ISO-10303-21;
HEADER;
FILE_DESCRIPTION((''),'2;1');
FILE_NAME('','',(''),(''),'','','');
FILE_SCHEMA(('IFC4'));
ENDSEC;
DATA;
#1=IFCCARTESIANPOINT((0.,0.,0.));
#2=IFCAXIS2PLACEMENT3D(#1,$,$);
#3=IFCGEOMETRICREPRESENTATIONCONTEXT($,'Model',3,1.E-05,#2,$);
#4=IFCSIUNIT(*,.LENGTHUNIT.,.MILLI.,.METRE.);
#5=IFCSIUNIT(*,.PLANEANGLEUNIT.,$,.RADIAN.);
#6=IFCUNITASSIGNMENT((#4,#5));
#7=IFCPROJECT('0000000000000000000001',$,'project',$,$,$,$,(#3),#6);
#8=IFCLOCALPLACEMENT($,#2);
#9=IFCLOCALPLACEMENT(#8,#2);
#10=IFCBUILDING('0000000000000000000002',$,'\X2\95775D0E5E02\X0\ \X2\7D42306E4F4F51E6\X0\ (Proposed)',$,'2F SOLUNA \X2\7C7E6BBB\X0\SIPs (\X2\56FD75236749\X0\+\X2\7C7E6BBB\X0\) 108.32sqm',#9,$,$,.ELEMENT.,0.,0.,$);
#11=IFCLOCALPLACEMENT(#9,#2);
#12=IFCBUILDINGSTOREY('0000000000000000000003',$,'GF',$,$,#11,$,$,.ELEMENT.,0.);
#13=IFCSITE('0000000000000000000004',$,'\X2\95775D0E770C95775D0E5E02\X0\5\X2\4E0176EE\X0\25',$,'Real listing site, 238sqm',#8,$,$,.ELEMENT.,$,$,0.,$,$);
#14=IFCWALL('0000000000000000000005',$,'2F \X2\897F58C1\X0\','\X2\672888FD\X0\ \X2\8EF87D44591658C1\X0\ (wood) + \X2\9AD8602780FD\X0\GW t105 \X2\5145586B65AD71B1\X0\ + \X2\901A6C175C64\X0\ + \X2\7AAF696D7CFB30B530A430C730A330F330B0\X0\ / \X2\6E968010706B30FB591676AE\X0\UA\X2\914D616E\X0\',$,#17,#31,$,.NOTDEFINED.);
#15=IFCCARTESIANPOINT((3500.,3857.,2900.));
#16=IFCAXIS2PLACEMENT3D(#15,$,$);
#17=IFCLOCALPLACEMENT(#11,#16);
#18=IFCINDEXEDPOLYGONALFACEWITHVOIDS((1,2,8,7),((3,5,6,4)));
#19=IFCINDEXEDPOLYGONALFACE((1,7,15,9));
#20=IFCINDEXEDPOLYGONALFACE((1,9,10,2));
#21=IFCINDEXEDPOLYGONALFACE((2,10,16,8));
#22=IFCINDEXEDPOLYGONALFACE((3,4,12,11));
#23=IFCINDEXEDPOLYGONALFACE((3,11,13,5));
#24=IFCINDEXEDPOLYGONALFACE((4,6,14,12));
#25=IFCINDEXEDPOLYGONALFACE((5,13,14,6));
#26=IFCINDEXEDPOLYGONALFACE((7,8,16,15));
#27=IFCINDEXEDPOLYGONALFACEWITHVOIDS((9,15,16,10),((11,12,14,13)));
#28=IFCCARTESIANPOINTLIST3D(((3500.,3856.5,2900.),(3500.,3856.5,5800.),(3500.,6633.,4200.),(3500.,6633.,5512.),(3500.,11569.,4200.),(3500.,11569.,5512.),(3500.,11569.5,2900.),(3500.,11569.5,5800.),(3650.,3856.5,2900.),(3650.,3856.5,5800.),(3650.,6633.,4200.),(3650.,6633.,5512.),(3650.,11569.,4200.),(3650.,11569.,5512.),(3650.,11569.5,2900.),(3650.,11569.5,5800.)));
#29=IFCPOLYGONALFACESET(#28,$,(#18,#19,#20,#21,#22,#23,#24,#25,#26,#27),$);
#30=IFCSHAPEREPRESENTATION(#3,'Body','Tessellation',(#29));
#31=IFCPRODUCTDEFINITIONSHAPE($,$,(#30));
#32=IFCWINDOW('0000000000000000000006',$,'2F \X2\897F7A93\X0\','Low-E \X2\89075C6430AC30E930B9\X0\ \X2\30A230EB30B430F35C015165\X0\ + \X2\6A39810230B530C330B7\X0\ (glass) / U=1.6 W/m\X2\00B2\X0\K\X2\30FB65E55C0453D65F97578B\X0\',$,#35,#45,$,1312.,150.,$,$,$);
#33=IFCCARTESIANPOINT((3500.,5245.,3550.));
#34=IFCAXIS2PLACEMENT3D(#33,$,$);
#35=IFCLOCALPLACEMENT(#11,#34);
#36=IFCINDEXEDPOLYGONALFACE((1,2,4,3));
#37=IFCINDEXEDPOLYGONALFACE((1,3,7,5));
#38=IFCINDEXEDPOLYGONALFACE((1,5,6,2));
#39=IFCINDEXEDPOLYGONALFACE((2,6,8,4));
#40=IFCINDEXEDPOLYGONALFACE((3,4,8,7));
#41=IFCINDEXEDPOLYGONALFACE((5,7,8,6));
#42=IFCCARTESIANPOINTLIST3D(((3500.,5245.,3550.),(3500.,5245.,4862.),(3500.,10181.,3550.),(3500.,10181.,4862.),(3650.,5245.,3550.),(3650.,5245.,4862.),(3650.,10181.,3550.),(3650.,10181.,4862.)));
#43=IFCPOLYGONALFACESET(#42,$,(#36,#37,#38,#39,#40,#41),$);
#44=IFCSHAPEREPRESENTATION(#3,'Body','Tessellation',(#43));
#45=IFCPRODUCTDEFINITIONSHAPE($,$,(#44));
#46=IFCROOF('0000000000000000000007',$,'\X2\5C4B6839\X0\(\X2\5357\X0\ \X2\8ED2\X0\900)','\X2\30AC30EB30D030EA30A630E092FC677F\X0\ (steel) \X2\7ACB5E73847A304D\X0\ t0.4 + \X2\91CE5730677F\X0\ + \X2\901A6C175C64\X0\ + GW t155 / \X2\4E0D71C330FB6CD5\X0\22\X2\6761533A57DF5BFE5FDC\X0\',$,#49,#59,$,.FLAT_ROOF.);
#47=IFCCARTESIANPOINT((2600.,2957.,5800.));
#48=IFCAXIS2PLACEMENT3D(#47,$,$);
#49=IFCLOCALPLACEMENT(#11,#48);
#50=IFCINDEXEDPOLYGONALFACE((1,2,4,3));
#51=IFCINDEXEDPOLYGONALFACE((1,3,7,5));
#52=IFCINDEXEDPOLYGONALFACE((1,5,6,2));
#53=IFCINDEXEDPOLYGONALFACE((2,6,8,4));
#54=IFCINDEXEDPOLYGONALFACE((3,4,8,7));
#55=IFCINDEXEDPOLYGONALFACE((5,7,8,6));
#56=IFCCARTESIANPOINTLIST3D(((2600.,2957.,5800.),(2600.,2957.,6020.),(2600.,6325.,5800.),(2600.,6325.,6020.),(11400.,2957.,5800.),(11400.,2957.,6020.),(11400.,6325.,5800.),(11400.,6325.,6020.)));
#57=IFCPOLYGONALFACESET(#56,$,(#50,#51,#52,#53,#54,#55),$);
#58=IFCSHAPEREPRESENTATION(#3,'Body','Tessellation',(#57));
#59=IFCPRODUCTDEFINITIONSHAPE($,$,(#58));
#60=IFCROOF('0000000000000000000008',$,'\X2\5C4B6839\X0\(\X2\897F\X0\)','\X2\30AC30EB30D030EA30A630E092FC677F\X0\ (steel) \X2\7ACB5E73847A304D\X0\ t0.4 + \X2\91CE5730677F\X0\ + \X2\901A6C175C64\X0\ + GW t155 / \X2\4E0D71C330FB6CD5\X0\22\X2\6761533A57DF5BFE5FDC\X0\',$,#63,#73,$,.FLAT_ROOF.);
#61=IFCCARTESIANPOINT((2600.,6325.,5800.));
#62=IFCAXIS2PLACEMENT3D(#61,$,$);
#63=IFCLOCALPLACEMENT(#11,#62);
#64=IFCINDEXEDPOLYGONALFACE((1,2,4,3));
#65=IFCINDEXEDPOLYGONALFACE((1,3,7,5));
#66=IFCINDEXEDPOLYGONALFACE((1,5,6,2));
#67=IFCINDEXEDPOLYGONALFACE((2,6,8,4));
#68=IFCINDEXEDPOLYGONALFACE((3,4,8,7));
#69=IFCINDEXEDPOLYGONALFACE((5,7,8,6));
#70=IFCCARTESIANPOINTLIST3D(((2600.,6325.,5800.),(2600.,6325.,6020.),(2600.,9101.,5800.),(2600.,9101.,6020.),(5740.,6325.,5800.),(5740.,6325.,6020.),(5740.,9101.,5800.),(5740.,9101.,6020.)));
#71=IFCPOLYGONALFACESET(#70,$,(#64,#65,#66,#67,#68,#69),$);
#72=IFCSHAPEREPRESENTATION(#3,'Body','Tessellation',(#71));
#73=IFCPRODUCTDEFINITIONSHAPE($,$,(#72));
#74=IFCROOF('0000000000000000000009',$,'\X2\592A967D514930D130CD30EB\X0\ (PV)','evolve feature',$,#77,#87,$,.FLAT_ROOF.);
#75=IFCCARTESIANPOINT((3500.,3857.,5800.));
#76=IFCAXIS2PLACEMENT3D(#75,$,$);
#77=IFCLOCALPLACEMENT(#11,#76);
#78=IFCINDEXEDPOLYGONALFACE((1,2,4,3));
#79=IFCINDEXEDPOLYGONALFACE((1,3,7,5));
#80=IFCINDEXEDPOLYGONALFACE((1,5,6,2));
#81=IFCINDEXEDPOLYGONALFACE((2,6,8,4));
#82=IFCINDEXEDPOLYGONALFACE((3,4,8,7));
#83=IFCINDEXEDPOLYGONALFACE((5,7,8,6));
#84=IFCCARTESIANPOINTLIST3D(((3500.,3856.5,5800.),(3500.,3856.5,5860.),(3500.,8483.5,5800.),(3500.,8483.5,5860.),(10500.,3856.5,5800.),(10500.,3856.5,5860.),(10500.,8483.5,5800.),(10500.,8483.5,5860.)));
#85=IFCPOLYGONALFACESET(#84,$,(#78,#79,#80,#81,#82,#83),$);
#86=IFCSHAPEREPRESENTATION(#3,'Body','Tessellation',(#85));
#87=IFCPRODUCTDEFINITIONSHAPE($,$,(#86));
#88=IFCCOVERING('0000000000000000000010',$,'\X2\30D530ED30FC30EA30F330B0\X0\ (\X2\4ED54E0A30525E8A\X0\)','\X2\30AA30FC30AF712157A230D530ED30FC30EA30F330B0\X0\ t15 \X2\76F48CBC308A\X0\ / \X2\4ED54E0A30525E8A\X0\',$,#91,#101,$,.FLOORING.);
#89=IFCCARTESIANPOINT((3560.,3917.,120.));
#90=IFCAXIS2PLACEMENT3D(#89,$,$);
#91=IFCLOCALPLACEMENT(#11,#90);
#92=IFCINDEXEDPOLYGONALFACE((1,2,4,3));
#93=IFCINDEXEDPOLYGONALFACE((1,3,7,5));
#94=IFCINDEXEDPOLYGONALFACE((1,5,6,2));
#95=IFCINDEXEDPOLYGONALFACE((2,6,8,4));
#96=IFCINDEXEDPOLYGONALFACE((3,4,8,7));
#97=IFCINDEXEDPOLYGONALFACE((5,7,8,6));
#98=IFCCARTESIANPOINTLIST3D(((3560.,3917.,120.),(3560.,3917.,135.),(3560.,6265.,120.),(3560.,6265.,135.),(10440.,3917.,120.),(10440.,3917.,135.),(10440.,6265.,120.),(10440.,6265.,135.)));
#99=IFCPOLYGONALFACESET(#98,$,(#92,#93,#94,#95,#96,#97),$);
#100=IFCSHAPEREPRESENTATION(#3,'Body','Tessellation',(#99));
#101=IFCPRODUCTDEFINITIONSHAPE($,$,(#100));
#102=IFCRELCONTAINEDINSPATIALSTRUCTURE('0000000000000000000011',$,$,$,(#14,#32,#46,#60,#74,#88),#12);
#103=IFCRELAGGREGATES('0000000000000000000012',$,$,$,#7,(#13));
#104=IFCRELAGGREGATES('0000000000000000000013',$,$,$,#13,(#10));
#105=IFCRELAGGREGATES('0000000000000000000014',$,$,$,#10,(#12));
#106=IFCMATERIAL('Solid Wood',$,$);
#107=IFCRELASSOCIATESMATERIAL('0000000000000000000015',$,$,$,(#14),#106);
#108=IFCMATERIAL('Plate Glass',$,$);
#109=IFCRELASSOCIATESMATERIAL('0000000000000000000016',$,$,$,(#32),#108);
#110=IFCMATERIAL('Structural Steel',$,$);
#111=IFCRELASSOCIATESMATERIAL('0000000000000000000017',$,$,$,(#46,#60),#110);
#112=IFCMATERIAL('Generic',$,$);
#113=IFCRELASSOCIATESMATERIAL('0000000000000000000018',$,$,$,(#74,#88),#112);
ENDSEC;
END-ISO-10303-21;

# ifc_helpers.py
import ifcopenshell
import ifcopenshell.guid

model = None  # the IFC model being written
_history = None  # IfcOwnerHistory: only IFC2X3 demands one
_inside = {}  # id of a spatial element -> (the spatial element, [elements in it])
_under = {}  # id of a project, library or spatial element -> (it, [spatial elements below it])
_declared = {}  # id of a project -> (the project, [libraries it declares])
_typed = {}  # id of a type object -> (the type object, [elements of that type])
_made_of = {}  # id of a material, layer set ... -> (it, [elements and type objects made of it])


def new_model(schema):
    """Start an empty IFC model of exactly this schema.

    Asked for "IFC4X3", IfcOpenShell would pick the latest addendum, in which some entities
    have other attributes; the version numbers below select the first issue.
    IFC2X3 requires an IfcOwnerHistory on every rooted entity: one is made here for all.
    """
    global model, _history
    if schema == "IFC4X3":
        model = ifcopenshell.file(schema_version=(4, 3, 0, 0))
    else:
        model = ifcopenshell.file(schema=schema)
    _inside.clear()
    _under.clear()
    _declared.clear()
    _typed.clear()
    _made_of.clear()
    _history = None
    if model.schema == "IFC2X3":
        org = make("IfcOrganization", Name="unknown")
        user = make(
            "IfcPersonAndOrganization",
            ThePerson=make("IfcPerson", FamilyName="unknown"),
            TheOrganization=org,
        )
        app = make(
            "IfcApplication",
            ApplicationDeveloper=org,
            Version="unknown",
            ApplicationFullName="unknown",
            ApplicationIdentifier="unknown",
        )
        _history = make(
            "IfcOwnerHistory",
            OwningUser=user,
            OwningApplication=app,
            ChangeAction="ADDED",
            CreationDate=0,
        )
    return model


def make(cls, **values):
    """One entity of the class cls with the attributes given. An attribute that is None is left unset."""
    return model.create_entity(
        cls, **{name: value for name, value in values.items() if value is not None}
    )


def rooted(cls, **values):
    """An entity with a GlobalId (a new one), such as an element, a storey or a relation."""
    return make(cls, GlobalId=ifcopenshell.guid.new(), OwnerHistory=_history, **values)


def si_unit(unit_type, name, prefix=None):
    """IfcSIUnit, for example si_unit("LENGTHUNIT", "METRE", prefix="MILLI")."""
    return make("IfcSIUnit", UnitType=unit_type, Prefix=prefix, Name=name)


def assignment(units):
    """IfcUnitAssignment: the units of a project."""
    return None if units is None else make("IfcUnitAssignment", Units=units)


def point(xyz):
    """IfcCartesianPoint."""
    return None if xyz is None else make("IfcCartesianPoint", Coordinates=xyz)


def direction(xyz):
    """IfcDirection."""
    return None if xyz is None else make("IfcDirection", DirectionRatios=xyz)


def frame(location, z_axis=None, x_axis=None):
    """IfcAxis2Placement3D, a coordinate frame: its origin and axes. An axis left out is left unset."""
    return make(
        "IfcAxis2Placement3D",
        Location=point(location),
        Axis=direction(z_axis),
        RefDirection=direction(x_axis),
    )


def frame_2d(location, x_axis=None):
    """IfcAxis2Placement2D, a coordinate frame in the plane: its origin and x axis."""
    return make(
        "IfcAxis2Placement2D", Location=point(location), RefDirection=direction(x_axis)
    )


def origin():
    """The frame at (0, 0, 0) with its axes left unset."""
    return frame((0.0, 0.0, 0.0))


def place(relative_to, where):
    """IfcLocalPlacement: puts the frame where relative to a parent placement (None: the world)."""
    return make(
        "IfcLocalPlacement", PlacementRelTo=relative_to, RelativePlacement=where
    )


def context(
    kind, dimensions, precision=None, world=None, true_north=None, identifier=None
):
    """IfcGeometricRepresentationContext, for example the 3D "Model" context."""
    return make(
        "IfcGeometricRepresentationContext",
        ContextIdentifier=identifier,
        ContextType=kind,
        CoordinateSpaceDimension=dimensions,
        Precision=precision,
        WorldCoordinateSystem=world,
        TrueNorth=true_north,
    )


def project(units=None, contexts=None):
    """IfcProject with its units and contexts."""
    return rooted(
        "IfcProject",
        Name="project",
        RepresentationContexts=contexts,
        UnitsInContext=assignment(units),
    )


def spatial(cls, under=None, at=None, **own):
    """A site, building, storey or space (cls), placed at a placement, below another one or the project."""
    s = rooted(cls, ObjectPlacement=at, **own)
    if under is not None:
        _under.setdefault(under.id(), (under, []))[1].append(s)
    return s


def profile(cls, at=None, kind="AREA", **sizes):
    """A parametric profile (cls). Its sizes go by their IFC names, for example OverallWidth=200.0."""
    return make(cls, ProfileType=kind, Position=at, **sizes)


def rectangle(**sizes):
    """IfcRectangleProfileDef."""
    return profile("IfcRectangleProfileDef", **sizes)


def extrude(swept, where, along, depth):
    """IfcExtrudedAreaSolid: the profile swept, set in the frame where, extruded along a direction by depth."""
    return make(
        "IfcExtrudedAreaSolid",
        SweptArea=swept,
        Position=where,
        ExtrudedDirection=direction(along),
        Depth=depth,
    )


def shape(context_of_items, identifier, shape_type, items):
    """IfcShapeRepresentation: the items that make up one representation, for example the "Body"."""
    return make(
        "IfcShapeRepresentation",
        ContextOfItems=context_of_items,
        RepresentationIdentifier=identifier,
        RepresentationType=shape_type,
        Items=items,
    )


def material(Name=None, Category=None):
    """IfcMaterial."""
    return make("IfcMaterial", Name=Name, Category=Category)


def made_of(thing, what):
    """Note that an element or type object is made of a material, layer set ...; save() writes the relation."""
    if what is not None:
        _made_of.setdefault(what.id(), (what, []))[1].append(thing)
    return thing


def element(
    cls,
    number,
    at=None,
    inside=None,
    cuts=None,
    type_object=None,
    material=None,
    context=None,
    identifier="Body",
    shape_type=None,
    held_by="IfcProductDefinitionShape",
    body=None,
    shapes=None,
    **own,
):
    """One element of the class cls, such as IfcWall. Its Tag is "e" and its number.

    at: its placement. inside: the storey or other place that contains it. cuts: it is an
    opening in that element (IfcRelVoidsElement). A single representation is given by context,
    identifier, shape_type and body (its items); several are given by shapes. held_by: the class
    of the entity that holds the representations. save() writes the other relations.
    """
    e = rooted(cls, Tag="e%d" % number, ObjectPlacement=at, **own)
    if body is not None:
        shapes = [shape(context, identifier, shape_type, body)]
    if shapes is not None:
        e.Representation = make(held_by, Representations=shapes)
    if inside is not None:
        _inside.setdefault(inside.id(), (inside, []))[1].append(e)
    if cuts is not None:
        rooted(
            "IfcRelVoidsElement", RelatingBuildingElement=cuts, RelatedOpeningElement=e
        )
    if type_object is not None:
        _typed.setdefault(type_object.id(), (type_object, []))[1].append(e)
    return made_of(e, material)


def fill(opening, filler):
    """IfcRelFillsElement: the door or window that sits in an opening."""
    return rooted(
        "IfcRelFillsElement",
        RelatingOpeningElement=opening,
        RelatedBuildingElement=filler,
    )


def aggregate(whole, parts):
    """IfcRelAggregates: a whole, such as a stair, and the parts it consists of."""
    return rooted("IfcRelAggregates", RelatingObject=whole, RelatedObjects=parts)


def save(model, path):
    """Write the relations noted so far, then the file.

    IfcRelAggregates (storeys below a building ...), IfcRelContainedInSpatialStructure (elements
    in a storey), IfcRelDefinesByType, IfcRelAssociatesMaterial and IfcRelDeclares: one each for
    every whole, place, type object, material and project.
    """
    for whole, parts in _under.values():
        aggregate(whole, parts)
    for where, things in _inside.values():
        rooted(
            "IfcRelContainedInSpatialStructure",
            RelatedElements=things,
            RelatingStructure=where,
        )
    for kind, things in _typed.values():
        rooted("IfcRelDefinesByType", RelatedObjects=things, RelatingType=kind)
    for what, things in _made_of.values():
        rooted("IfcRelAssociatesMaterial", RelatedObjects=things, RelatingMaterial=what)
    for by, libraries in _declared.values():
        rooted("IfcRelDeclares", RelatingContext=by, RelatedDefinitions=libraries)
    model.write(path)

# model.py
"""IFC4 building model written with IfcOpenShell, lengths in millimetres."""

from ifc_helpers import new_model, si_unit, frame, frame_2d, origin, place, context, project, spatial, rectangle, extrude, material, element, fill, save


model = new_model("IFC4")

# Units and contexts
model_context = context("Model", 3, precision=1e-05, world=origin())
ifc_project = project(units=[si_unit("LENGTHUNIT", "METRE", prefix="MILLI"), si_unit("PLANEANGLEUNIT", "RADIAN")], contexts=[model_context])

# Site, building, storey
site_placement = place(None, origin())
site = spatial("IfcSite", under=ifc_project, at=site_placement, Name="長崎県長崎市5丁目25", ObjectType="Real listing site, 238sqm", CompositionType="ELEMENT", RefElevation=0.0)
building_placement = place(site_placement, origin())
building = spatial("IfcBuilding", under=site, at=building_placement, Name="長崎市 終の住処 (Proposed)", ObjectType="2F SOLUNA 籾殻SIPs (国産杉+籾殻) 108.32sqm", CompositionType="ELEMENT", ElevationOfRefHeight=0.0, ElevationOfTerrain=0.0)
storey_placement = place(building_placement, origin())
storey = spatial("IfcBuildingStorey", under=building, at=storey_placement, Name="GF", CompositionType="ELEMENT", Elevation=0.0)

# Shared definitions
ifc_material_1 = material(Name="Solid Wood")
ifc_material_2 = material(Name="Generic")

# Shared definitions
ifc_material_3 = material(Name="Plate Glass")

# Wall, opening, window
wall_1_placement = place(storey_placement, frame((3500.0, 3857.0, 2900.0)))
wall_1 = element("IfcWall", 1, at=wall_1_placement, inside=storey, material=ifc_material_1, Name="2F 西壁", Description="木製 軸組外壁 (wood) + 高性能GW t105 充填断熱 + 通気層 + 窯業系サイディング / 準耐火・外皮UA配慮", PredefinedType="NOTDEFINED", context=model_context, shape_type="SweptSolid", body=[
    extrude(rectangle(XDim=150.0, YDim=7713.0, at=frame_2d((75.0, 3856.0))), frame((3500.0, 3857.0, 2900.0)), (0.0, 0.0, 1.0), 2900.0),
])
opening_1_placement = place(storey_placement, frame((3500.0, 5245.0, 3550.0)))
opening_1 = element("IfcOpeningElement", 2, at=opening_1_placement, cuts=wall_1, PredefinedType="NOTDEFINED", context=model_context, shape_type="SweptSolid", body=[
    extrude(rectangle(XDim=150.0, YDim=4936.0, at=frame_2d((75.0, 2468.0))), frame((3500.0, 5245.0, 3550.0)), (0.0, 0.0, 1.0), 1312.0),
])
window_1_placement = place(storey_placement, frame((3500.0, 5245.0, 3550.0)))
window_1 = element("IfcWindow", 3, at=window_1_placement, inside=storey, material=ifc_material_3, Name="2F 西窓", Description="Low-E 複層ガラス アルゴン封入 + 樹脂サッシ (glass) / U=1.6 W/m²K・日射取得型", OverallHeight=1312.0, OverallWidth=150.0, context=model_context, shape_type="SweptSolid", body=[
    extrude(rectangle(XDim=150.0, YDim=4936.0, at=frame_2d((75.0, 2468.0))), frame((3500.0, 5245.0, 3550.0)), (0.0, 0.0, 1.0), 1312.0),
])
fill(opening_1, window_1)

# Roofs
ifc_material_4 = material(Name="Structural Steel")
roof_1_placement = place(storey_placement, frame((2600.0, 2957.0, 5800.0)))
element("IfcRoof", 4, at=roof_1_placement, inside=storey, material=ifc_material_4, Name="屋根(南 軒900)", Description="ガルバリウム鋼板 (steel) 立平葺き t0.4 + 野地板 + 通気層 + GW t155 / 不燃・法22条区域対応", PredefinedType="FLAT_ROOF", context=model_context, shape_type="SweptSolid", body=[
    extrude(rectangle(XDim=8800.0, YDim=3368.0, at=frame_2d((4400.0, 1684.0))), frame((2600.0, 2957.0, 5800.0)), (0.0, 0.0, 1.0), 220.0),
])
roof_2_placement = place(storey_placement, frame((2600.0, 6325.0, 5800.0)))
element("IfcRoof", 5, at=roof_2_placement, inside=storey, material=ifc_material_4, Name="屋根(西)", Description="ガルバリウム鋼板 (steel) 立平葺き t0.4 + 野地板 + 通気層 + GW t155 / 不燃・法22条区域対応", PredefinedType="FLAT_ROOF", context=model_context, shape_type="SweptSolid", body=[
    extrude(rectangle(XDim=3140.0, YDim=2776.0, at=frame_2d((1570.0, 1388.0))), frame((2600.0, 6325.0, 5800.0)), (0.0, 0.0, 1.0), 220.0),
])
roof_3_placement = place(storey_placement, frame((3500.0, 3857.0, 5800.0)))
element("IfcRoof", 6, at=roof_3_placement, inside=storey, material=ifc_material_2, Name="太陽光パネル (PV)", Description="evolve feature", PredefinedType="FLAT_ROOF", context=model_context, shape_type="SweptSolid", body=[
    extrude(rectangle(XDim=7000.0, YDim=4627.0, at=frame_2d((3500.0, 2313.0))), frame((3500.0, 3857.0, 5800.0)), (0.0, 0.0, 1.0), 60.0),
])

# Covering
covering_placement = place(storey_placement, frame((3560.0, 3917.0, 120.0)))
element("IfcCovering", 7, at=covering_placement, inside=storey, material=ifc_material_2, Name="フローリング (仕上げ床)", Description="オーク無垢フローリング t15 直貼り / 仕上げ床", PredefinedType="FLOORING", context=model_context, shape_type="SweptSolid", body=[
    extrude(rectangle(XDim=6880.0, YDim=2348.0, at=frame_2d((3440.0, 1174.0))), frame((3560.0, 3917.0, 120.0)), (0.0, 0.0, 1.0), 15.0),
])

save(model, "model.ifc")
